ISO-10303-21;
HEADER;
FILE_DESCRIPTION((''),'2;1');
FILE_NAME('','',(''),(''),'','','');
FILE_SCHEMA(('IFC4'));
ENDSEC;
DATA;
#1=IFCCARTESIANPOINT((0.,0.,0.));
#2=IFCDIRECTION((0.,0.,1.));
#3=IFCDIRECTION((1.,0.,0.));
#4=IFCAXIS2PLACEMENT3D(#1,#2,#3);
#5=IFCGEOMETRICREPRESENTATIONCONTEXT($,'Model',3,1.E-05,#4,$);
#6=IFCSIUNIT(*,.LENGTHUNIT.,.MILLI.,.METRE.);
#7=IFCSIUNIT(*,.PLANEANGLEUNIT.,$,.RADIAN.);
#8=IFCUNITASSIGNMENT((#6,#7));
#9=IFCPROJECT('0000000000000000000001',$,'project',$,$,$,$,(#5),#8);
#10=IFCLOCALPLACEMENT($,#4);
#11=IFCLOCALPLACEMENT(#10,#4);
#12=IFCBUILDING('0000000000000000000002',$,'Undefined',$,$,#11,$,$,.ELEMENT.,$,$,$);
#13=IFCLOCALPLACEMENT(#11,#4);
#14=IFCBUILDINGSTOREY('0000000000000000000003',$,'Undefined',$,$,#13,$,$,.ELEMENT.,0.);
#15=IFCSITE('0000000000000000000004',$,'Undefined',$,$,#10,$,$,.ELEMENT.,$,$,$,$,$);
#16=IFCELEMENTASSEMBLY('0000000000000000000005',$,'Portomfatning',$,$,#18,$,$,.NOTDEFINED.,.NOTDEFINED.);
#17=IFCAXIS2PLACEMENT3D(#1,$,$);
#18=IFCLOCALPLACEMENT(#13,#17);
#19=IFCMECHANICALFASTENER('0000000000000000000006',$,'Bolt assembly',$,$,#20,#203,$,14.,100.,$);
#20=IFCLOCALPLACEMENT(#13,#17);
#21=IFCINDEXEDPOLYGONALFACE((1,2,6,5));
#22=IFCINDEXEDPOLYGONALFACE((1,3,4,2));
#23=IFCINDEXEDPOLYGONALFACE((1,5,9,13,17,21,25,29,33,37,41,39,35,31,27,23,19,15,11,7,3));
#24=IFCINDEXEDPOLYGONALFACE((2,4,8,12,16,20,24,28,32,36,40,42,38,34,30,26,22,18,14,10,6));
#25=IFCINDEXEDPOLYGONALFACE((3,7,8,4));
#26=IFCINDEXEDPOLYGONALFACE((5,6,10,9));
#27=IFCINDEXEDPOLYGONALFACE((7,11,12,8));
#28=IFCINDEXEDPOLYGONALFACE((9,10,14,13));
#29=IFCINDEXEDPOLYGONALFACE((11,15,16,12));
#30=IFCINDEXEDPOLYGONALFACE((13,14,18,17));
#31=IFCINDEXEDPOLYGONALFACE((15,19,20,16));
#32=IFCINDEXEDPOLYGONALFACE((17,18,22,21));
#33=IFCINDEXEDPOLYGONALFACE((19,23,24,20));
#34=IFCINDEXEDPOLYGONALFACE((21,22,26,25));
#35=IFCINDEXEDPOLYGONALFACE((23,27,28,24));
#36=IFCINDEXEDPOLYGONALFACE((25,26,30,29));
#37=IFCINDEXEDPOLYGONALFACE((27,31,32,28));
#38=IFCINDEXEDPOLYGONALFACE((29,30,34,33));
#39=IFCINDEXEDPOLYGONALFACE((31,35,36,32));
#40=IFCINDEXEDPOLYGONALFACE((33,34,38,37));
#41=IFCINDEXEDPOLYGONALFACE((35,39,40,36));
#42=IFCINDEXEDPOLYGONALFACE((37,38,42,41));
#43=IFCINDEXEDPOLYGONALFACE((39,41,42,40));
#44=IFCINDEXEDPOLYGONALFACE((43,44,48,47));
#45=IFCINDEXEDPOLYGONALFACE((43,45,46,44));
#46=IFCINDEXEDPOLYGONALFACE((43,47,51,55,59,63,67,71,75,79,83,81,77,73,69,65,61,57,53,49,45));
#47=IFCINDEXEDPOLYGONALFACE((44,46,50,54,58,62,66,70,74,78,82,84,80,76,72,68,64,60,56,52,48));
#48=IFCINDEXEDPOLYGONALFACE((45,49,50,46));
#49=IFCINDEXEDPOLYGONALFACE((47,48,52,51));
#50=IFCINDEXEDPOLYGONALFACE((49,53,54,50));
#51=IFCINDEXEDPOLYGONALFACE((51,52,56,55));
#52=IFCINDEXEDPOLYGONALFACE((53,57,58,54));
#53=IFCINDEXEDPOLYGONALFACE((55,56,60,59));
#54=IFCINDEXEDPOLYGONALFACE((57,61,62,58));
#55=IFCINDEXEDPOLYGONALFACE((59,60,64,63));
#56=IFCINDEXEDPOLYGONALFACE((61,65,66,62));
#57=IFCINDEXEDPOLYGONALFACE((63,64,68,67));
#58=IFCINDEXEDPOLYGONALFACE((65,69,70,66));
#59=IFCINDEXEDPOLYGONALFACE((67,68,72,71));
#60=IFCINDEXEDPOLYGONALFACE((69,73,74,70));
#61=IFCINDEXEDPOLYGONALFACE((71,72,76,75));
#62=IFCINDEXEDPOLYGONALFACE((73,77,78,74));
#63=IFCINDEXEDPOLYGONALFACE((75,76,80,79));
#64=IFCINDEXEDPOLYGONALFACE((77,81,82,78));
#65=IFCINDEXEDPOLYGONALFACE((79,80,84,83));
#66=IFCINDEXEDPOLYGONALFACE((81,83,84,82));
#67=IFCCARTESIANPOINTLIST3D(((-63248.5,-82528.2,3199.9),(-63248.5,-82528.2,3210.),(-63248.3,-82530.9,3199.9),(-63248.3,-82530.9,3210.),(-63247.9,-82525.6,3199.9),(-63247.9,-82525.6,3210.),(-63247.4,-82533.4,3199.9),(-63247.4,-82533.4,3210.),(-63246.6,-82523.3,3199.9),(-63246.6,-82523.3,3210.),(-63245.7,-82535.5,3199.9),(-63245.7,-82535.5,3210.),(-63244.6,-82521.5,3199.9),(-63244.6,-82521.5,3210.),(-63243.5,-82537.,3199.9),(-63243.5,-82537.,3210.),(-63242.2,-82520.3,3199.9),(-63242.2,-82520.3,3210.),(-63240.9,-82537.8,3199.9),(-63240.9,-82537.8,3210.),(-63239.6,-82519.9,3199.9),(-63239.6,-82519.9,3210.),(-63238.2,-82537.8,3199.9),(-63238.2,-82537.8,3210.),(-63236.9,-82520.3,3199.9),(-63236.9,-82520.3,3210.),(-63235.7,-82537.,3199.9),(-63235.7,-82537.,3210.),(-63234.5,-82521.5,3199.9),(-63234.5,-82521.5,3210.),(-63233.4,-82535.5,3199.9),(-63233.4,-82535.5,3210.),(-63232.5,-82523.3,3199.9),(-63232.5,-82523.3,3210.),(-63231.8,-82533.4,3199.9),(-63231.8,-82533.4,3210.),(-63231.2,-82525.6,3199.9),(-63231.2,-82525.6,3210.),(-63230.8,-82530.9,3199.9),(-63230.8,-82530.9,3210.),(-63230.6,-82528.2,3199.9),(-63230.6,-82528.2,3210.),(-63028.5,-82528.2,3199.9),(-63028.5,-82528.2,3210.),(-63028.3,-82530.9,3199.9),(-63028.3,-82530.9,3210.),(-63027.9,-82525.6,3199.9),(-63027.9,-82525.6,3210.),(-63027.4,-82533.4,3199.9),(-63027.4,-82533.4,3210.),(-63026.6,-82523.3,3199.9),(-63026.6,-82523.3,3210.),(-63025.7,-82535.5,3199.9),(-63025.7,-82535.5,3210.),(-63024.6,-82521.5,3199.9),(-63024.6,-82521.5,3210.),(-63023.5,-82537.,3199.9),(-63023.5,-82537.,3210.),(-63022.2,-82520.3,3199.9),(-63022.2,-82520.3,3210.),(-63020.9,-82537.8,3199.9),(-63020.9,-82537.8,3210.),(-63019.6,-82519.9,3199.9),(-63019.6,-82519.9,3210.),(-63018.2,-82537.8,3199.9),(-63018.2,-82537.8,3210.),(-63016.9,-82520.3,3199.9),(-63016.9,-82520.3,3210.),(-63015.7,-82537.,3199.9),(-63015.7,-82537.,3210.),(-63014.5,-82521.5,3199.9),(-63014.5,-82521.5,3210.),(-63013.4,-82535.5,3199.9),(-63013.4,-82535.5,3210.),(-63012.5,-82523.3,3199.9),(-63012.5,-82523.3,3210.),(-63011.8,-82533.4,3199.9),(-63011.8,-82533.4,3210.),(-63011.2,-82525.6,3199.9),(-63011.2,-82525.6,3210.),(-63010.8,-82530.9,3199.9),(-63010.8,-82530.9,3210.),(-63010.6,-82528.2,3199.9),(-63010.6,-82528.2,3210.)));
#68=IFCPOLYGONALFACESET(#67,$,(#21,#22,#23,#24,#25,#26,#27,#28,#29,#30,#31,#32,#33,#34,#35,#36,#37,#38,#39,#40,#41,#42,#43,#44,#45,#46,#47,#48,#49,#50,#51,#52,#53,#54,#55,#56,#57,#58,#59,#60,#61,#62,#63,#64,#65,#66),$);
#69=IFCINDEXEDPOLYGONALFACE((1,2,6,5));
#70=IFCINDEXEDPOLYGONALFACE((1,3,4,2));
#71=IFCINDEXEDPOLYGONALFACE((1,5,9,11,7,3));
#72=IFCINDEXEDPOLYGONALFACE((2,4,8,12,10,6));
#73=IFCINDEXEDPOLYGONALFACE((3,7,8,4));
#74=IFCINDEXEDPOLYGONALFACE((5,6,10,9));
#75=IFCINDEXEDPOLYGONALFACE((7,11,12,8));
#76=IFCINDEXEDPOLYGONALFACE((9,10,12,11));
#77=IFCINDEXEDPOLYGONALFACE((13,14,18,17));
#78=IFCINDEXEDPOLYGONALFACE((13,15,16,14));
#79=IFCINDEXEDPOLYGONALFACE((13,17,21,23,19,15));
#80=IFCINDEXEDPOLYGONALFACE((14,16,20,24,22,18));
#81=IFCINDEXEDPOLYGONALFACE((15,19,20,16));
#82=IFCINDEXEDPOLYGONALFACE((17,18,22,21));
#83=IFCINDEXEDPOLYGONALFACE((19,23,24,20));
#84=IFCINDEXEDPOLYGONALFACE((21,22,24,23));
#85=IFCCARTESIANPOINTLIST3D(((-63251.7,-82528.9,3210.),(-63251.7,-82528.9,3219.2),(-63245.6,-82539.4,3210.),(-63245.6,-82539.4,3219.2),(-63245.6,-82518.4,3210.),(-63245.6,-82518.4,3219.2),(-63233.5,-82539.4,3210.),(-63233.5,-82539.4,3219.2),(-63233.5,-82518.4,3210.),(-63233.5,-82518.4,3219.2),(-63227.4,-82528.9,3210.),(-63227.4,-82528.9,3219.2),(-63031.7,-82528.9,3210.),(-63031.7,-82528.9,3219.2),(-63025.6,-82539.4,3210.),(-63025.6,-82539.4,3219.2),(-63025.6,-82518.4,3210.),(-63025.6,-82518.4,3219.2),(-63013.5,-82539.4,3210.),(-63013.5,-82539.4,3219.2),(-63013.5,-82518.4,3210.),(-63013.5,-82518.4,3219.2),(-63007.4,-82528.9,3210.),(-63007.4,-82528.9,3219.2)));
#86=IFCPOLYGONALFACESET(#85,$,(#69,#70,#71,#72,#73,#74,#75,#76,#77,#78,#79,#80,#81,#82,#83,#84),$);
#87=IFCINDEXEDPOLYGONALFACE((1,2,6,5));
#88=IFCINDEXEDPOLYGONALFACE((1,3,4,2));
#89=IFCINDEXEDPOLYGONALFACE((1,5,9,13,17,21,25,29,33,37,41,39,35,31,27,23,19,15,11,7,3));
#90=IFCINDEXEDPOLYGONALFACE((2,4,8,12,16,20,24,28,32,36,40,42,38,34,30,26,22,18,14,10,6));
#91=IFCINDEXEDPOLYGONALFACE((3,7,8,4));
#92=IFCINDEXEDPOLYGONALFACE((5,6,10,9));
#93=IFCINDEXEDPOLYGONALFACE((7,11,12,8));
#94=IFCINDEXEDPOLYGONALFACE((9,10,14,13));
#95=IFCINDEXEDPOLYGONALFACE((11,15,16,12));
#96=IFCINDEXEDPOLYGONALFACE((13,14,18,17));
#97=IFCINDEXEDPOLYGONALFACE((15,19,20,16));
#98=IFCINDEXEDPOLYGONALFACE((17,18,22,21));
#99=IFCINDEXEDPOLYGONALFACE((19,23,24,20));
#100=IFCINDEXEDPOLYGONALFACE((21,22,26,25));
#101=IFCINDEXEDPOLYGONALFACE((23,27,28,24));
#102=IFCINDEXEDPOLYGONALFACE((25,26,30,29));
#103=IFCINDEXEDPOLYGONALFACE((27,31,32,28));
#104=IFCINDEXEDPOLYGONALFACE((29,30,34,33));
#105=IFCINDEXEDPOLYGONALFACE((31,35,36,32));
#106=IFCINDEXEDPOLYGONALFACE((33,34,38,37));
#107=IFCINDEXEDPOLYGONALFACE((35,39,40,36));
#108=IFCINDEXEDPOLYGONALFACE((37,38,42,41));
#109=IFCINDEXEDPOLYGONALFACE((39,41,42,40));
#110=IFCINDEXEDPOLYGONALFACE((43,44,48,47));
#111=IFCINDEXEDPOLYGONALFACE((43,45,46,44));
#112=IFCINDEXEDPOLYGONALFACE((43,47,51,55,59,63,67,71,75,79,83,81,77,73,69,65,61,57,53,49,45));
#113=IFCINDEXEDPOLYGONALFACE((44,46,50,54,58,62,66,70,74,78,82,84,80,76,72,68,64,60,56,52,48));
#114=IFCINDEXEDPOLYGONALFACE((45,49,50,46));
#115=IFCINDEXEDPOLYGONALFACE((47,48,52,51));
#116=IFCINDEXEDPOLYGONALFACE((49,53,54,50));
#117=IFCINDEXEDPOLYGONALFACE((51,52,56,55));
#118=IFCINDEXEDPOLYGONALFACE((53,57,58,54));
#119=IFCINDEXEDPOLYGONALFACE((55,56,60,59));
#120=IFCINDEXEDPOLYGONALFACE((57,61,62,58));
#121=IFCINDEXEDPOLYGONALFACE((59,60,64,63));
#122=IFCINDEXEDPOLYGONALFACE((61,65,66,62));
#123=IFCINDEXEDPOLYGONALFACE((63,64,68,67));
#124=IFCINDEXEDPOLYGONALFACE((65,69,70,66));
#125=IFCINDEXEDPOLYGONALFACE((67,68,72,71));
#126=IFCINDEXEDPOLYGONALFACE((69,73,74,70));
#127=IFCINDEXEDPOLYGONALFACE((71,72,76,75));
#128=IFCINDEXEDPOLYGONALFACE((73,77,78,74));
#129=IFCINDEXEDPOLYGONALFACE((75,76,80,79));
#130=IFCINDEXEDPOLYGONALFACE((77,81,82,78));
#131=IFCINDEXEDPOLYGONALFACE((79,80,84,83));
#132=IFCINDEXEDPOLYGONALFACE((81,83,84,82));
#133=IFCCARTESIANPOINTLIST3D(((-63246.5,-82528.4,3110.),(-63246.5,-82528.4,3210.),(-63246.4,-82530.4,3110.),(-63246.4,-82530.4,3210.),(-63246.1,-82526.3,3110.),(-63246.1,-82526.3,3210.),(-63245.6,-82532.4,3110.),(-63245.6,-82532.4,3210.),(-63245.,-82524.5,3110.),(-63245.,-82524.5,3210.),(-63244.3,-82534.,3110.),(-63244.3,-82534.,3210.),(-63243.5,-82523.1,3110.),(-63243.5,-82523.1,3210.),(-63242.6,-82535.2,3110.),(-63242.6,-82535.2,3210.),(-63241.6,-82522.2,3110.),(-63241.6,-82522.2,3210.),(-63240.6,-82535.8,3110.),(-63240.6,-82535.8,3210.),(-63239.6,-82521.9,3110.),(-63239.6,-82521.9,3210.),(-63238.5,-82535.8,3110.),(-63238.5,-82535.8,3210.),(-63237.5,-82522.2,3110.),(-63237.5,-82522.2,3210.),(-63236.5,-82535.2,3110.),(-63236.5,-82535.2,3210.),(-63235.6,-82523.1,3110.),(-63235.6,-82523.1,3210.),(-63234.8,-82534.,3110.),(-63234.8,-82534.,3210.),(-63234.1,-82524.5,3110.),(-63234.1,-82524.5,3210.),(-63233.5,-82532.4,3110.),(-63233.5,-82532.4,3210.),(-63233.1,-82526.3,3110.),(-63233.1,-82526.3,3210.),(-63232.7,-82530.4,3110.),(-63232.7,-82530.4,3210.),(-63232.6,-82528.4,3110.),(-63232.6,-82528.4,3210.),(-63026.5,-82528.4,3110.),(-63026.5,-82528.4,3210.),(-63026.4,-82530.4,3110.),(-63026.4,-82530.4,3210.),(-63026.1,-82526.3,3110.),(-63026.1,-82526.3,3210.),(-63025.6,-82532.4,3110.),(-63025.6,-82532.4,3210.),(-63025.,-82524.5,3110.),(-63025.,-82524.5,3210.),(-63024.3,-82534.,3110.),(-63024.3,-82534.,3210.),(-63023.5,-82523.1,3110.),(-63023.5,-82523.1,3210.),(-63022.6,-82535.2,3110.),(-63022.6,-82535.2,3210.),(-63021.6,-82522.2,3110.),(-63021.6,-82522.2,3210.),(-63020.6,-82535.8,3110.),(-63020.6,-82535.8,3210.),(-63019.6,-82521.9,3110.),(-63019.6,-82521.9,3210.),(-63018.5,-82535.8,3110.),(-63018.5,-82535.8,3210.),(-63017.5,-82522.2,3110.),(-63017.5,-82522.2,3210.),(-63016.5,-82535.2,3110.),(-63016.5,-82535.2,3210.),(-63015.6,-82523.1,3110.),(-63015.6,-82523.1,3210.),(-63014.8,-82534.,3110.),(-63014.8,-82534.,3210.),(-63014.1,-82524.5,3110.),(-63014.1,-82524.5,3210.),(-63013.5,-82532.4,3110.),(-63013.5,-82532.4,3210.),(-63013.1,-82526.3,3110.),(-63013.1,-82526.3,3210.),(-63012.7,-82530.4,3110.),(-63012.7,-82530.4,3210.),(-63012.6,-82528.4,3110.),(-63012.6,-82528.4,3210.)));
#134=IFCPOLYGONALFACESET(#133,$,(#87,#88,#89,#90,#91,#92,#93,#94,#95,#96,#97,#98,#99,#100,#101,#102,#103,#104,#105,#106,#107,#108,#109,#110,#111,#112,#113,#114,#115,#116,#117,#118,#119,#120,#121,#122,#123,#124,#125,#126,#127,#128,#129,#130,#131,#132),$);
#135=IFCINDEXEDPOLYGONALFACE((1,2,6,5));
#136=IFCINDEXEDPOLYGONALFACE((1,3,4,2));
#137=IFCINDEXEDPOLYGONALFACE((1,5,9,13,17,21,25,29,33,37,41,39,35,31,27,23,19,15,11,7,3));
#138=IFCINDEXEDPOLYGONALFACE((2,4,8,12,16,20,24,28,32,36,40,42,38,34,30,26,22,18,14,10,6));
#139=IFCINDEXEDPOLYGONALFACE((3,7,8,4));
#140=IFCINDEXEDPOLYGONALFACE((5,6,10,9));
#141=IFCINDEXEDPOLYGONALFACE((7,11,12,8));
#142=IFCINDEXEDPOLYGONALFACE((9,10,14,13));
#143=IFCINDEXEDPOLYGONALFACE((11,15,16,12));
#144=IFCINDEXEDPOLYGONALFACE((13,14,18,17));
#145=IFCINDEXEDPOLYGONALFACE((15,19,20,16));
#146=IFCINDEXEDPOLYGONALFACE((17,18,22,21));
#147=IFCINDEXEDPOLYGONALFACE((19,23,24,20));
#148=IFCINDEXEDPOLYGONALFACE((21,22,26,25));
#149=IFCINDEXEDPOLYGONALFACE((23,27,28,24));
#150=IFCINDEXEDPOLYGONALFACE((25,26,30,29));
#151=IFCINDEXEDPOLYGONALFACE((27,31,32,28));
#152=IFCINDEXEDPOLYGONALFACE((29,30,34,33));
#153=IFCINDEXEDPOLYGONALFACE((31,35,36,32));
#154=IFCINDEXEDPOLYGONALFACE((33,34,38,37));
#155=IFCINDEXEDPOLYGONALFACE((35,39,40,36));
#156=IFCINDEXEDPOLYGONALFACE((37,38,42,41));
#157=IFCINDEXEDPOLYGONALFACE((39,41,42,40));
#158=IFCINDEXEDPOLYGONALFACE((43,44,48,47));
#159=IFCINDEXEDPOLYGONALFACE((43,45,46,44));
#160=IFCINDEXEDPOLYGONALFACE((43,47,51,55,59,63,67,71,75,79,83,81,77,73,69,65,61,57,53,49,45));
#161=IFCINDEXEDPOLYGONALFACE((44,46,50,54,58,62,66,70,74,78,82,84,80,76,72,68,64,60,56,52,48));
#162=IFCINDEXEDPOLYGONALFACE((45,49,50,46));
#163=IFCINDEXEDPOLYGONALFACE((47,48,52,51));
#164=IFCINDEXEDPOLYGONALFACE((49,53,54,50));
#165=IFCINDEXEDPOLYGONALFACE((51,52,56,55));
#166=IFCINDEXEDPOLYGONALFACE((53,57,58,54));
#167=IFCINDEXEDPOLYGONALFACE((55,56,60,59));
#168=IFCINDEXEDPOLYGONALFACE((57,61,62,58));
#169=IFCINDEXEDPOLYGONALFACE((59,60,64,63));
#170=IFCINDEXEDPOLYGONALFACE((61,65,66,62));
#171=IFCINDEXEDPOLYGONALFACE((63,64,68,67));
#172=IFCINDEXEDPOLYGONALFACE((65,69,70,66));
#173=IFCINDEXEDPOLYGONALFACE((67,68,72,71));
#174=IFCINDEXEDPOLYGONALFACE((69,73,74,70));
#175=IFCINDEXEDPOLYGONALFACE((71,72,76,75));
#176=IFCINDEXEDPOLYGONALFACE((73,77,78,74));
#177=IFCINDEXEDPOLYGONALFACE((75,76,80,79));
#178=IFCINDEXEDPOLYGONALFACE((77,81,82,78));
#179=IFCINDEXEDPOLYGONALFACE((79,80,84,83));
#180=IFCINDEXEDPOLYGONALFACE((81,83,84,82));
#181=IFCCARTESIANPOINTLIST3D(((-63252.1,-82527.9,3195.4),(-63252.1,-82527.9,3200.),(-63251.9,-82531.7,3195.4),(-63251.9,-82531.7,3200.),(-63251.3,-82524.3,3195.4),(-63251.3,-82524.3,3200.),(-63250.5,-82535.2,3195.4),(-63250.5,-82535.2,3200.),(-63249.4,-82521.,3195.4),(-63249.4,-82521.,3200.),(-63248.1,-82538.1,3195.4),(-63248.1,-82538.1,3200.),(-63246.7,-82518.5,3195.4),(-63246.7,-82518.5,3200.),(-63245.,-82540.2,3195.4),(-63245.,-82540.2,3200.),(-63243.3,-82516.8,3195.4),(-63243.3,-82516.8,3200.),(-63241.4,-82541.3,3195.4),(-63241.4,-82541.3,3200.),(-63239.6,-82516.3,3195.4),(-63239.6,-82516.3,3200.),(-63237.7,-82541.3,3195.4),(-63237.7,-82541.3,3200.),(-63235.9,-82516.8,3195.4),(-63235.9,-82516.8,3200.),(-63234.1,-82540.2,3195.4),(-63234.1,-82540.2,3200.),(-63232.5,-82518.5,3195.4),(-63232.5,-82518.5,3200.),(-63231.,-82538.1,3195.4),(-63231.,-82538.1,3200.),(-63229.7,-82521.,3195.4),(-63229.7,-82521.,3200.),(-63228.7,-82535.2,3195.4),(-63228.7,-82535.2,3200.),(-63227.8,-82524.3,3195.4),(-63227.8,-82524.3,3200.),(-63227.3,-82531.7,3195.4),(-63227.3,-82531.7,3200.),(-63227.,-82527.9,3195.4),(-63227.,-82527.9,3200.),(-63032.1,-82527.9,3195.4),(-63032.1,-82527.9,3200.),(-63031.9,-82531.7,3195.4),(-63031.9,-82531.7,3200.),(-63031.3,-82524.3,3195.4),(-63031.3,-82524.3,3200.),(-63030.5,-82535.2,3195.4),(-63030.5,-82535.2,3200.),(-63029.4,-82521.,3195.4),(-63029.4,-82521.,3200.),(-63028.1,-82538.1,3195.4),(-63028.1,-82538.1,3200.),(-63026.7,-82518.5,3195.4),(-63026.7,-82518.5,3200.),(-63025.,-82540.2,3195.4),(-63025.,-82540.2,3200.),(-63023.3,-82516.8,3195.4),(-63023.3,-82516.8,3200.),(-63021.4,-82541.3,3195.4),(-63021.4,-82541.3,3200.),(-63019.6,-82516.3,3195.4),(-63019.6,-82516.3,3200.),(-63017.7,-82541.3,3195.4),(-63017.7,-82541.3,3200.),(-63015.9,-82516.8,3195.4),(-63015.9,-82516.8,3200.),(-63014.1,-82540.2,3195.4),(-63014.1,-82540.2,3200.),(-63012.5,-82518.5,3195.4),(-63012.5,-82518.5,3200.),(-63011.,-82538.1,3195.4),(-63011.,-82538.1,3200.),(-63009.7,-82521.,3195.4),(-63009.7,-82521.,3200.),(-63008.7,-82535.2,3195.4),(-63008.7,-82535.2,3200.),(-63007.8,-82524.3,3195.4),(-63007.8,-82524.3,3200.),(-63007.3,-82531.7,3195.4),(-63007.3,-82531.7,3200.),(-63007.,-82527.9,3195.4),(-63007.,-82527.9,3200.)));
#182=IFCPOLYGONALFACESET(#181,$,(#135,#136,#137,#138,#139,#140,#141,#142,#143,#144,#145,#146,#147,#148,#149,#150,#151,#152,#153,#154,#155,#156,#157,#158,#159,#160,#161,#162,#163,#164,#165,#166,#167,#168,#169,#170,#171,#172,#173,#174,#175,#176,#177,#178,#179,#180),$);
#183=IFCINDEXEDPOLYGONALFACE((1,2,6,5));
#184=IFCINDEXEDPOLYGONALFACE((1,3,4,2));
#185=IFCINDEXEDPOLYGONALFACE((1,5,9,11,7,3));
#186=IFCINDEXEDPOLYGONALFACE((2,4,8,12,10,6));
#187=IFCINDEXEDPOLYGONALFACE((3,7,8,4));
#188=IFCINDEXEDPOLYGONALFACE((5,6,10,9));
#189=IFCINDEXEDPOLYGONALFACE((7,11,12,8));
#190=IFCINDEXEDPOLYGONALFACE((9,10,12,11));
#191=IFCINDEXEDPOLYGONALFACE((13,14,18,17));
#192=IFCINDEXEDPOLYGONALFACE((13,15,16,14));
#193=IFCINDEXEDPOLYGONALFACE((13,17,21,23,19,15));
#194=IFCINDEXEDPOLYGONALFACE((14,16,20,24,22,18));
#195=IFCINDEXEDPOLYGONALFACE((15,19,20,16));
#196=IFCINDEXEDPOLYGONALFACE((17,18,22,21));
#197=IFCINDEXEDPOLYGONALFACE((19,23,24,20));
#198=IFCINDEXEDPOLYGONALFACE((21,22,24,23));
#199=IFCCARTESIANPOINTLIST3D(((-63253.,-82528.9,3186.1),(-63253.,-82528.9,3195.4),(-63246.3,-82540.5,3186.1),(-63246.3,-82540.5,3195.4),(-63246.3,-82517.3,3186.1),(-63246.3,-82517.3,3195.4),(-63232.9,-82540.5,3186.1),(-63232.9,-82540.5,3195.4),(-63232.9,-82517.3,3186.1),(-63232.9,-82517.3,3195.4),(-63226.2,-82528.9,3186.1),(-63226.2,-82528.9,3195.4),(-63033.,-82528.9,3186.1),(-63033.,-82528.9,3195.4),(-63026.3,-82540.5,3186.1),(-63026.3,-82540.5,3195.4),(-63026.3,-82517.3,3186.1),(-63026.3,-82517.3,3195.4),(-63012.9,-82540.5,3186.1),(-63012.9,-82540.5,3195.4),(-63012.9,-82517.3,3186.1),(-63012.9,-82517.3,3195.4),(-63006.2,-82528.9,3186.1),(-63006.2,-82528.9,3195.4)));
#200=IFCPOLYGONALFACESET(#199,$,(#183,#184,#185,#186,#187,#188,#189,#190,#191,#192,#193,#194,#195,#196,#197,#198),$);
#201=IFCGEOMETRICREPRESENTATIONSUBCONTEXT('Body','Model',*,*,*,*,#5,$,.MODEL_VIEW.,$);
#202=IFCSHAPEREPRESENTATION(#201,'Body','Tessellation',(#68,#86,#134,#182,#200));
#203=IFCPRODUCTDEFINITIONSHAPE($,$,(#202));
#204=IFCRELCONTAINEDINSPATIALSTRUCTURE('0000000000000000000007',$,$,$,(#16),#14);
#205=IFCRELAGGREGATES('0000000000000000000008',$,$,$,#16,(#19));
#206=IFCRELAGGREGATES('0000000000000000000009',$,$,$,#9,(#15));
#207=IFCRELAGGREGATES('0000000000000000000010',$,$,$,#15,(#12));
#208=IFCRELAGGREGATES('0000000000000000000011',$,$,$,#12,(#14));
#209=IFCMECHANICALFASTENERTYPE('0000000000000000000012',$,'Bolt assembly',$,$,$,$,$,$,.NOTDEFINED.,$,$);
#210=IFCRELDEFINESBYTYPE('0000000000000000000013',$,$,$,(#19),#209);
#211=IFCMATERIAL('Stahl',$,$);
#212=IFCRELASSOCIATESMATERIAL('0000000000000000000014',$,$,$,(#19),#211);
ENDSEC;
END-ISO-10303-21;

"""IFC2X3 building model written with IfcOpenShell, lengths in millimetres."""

from ifc_helpers import new_model, si_unit, frame, origin_with_axes, origin_2d_with_axis, place, context, subcontext, project, spatial, polyline, circle, outline, extrude, source, transform, mapped, material, type_object, element, aggregate, save


model = new_model("IFC2X3")

# Units and contexts
model_context = context("Model", 3, precision=1e-05, world=origin_with_axes())
body_context = subcontext(model_context, "Body", "Model", "MODEL_VIEW")
ifc_project = project(units=[si_unit("LENGTHUNIT", "METRE", prefix="MILLI"), si_unit("PLANEANGLEUNIT", "RADIAN")], contexts=[model_context])

# Site, building, storey
site_placement = place(None, origin_with_axes())
site = spatial("IfcSite", under=ifc_project, at=site_placement, Name="Undefined", CompositionType="ELEMENT")
building_placement = place(site_placement, origin_with_axes())
building = spatial("IfcBuilding", under=site, at=building_placement, Name="Undefined", CompositionType="ELEMENT")
storey_placement = place(building_placement, origin_with_axes())
storey = spatial("IfcBuildingStorey", under=building, at=storey_placement, Name="Undefined", CompositionType="ELEMENT", Elevation=0.0)

# Element assembly
assembly_1_placement = place(storey_placement, origin_with_axes())
assembly_1 = element("IfcElementAssembly", 1, at=assembly_1_placement, inside=storey, Name="Portomfatning", AssemblyPlace="NOTDEFINED", PredefinedType="NOTDEFINED")

# Mechanical fastener
ifc_material_1 = material(Name="Stahl")
mechanical_fastener_type = type_object("IfcMechanicalFastenerType", Name="Bolt assembly")
shared_shape_1 = source(origin_with_axes(), body_context, "Body", "SweptSolid", [
    extrude(circle(Radius=9.0, at=origin_2d_with_axis()), frame((0.0, 0.0, 0.0), z_axis=(0.0, 1.0, 0.0), x_axis=(1.0, 0.0, 0.0)), (0.0, 0.0, 1.0), 10.1),
    extrude(outline(polyline([(10.5, -6.1), (10.5, 6.1), (0.0, 12.1), (-10.5, 6.1), (-10.5, -6.1), (0.0, -12.1), (10.5, -6.1)])), frame((0.0, -9.2, 0.0), z_axis=(0.0, 1.0, 0.0), x_axis=(1.0, 0.0, 0.0)), (0.0, 0.0, 1.0), 9.2),
    extrude(circle(Radius=7.0, at=origin_2d_with_axis()), frame((0.0, 0.0, 0.0), z_axis=(0.0, 1.0, 0.0), x_axis=(1.0, 0.0, 0.0)), (0.0, 0.0, 1.0), 100.0),
    extrude(circle(Radius=12.6, at=origin_2d_with_axis()), frame((0.0, 10.0, 0.0), z_axis=(0.0, 1.0, 0.0), x_axis=(1.0, 0.0, 0.0)), (0.0, 0.0, 1.0), 4.6),
    extrude(outline(polyline([(11.6, -6.7), (11.6, 6.7), (0.0, 13.4), (-11.6, 6.7), (-11.6, -6.7), (0.0, -13.4), (11.6, -6.7)])), frame((0.0, 14.6, 0.0), z_axis=(0.0, 1.0, 0.0), x_axis=(1.0, 0.0, 0.0)), (0.0, 0.0, 1.0), 9.2),
])
mechanical_fastener_1_placement = place(assembly_1_placement, frame((-63129.6, -82528.9, 3210.0), z_axis=(-1.0, 0.0, 0.0), x_axis=(0.0, 1.0, 0.0)))
mechanical_fastener_1 = element("IfcMechanicalFastener", 2, at=mechanical_fastener_1_placement, type_object=mechanical_fastener_type, material=ifc_material_1, Name="Bolt assembly", NominalDiameter=14.0, NominalLength=100.0, context=body_context, shape_type="MappedRepresentation", body=[
    mapped(shared_shape_1, transform((0.0, 0.0, -110.0))),
    mapped(shared_shape_1, transform((0.0, 0.0, 110.0))),
])
aggregate(assembly_1, [mechanical_fastener_1])

save(model, "model.ifc")
